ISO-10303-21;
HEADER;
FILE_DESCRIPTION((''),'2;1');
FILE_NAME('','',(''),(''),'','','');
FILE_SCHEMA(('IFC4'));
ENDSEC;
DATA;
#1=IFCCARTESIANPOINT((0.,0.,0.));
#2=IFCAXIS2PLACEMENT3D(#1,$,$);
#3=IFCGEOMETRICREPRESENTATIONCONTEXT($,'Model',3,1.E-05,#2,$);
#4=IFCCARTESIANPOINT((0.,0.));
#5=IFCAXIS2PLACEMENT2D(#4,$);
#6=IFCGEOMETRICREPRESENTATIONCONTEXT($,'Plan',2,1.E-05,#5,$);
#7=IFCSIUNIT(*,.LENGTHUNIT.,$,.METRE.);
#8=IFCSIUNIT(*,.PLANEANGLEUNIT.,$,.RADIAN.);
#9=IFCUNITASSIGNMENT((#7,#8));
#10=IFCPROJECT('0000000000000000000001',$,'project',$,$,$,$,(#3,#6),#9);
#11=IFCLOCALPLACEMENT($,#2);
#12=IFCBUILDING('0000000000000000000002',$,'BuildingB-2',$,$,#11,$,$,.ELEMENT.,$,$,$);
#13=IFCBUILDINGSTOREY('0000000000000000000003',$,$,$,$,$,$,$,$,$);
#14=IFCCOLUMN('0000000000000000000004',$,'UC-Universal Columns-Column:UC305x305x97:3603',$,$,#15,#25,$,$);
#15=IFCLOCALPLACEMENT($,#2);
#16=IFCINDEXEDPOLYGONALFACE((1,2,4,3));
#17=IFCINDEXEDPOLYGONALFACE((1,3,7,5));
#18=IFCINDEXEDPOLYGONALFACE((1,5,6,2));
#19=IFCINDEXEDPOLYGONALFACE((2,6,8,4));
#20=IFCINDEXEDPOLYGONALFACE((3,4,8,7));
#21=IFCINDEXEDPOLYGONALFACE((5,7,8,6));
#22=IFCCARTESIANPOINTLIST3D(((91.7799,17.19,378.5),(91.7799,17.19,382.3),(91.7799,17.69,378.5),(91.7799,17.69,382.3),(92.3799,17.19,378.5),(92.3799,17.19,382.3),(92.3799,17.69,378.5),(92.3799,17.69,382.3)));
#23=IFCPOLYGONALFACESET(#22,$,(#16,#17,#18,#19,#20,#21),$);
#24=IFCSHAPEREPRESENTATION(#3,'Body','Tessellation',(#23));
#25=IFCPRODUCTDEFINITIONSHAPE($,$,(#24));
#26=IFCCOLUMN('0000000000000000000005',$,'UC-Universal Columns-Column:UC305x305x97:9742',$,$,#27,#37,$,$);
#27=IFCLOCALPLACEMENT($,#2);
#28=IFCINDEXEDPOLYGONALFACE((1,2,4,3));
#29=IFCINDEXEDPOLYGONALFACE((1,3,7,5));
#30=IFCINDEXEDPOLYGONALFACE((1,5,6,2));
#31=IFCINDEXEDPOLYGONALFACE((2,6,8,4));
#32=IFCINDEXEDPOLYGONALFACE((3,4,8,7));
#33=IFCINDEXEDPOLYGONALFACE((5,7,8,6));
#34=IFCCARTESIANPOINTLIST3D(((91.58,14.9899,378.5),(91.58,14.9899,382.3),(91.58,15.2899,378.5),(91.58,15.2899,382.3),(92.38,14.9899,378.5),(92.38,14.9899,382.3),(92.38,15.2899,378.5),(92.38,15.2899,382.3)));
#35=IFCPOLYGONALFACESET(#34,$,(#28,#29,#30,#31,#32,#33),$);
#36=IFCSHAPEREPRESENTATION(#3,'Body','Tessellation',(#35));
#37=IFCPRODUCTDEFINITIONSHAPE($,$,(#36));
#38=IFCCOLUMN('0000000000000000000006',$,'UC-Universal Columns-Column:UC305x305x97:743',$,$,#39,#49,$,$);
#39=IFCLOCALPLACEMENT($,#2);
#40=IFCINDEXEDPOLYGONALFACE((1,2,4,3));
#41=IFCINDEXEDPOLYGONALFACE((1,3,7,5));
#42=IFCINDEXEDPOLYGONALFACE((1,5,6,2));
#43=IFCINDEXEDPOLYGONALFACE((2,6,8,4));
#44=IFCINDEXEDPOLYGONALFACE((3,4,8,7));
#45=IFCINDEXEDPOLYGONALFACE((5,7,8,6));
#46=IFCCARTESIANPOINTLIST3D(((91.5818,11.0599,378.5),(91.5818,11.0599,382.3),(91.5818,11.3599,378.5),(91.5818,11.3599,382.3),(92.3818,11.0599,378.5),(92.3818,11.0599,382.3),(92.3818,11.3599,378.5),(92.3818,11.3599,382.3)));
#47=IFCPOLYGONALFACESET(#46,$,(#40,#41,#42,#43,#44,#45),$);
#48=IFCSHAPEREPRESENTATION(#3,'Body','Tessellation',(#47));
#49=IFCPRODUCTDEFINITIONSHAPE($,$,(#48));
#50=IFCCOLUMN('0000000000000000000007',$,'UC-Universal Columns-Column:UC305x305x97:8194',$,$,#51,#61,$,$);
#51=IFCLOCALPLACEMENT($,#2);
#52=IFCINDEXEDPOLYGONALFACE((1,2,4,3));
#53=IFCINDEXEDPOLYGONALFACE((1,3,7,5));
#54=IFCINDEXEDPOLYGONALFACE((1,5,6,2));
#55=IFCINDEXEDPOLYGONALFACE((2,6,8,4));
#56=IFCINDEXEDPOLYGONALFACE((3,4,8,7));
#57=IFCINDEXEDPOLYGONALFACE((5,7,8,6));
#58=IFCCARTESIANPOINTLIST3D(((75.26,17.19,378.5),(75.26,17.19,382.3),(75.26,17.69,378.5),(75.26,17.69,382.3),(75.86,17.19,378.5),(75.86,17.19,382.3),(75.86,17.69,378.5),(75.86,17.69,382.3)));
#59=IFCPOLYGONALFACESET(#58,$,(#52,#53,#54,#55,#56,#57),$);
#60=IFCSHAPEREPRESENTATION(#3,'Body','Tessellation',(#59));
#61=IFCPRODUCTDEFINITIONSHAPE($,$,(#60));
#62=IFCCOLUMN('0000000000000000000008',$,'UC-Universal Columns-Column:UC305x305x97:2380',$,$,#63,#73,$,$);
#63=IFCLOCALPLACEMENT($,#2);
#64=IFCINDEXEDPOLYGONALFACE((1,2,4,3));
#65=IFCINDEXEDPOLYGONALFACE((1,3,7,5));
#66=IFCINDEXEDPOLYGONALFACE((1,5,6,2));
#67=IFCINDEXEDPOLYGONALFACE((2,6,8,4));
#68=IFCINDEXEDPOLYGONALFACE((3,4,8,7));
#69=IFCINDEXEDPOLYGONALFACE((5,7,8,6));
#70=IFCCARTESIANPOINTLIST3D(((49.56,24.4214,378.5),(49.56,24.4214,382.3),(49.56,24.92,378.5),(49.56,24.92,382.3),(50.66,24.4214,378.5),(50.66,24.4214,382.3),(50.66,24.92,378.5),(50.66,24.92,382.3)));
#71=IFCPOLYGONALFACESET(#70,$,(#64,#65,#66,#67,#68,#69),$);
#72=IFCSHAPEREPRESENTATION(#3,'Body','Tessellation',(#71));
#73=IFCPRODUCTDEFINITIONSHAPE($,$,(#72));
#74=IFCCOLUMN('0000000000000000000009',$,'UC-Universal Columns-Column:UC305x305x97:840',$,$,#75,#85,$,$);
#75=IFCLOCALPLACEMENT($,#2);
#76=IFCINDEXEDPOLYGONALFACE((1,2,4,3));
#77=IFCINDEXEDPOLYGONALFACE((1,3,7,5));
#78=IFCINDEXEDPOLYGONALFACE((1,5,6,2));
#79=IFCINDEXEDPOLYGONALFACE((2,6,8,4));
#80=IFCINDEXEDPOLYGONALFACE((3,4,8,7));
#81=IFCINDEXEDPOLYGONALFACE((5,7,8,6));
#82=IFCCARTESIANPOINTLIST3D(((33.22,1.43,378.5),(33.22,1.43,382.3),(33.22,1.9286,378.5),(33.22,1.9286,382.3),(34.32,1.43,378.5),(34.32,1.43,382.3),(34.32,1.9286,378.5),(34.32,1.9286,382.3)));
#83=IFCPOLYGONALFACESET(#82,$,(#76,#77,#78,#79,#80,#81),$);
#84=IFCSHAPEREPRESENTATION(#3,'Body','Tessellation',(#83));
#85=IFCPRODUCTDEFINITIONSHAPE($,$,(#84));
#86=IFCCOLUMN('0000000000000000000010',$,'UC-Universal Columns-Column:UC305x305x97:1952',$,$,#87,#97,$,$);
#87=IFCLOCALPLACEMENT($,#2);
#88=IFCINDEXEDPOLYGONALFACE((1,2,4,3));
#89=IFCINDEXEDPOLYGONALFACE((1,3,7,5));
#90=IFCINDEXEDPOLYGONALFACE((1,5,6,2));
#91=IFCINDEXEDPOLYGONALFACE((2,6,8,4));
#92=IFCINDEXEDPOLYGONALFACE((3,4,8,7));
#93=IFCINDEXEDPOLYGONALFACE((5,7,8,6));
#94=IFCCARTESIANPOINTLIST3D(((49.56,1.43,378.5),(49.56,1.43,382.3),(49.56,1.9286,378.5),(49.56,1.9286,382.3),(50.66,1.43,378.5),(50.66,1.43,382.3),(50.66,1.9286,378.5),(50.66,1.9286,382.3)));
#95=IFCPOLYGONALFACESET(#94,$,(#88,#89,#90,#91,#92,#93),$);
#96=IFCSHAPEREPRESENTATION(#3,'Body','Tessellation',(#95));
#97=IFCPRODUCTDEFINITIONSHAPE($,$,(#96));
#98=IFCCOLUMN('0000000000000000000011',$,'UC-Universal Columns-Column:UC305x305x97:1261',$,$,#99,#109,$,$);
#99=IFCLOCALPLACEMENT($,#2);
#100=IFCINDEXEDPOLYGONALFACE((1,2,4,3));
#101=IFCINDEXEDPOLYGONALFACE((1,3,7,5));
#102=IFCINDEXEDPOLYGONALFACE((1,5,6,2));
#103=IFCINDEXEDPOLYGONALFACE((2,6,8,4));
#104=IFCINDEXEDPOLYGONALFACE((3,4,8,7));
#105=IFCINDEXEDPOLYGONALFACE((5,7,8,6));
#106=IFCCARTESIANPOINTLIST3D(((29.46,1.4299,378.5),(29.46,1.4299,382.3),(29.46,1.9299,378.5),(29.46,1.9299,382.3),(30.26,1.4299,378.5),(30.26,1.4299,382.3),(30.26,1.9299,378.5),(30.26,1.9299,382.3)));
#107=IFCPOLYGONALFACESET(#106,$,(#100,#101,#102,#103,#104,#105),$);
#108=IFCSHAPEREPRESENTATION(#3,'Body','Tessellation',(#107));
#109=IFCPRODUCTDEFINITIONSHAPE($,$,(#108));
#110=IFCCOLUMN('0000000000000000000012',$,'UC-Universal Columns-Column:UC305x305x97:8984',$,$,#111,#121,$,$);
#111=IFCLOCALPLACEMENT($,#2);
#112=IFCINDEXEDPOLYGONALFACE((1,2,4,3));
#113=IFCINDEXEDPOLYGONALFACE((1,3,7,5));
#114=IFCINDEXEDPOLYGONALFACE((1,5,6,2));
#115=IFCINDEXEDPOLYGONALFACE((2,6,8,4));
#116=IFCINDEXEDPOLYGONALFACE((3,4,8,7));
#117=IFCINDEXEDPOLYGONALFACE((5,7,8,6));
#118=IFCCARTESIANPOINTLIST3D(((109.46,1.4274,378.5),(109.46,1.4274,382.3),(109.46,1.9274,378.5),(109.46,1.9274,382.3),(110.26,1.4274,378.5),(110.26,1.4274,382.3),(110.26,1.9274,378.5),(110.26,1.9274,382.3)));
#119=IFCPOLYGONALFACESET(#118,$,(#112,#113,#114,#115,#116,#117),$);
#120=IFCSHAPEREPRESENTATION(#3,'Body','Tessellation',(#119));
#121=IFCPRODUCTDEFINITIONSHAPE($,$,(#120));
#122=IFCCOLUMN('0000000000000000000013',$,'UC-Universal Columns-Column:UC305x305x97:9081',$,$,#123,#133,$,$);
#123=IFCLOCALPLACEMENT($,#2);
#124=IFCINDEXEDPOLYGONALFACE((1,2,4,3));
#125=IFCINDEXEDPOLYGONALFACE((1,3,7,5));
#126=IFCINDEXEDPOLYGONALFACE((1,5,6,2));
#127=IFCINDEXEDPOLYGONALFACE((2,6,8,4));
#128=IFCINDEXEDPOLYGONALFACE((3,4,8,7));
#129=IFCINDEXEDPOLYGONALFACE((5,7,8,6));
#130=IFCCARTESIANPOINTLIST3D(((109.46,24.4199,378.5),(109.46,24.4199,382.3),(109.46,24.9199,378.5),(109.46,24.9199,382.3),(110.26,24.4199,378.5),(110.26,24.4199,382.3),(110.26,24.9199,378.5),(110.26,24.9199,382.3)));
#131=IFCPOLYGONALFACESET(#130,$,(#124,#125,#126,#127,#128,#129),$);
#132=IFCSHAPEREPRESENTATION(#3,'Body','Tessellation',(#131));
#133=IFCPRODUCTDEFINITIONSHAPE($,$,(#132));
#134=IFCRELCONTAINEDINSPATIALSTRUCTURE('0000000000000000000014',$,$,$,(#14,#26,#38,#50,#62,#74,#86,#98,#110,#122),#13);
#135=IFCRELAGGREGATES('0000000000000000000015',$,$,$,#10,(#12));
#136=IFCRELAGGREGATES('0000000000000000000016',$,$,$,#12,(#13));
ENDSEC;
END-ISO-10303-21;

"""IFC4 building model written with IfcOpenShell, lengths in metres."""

from ifc_helpers import new_model, si_unit, origin, origin_2d, place, context, project, spatial, polyline, outline, extrude, element, save


model = new_model("IFC4")

# Units and contexts
model_context = context("Model", 3, precision=1e-05, world=origin())
plan_context = context("Plan", 2, precision=1e-05, world=origin_2d())
ifc_project = project(units=[si_unit("LENGTHUNIT", "METRE"), si_unit("PLANEANGLEUNIT", "RADIAN")], contexts=[model_context, plan_context])

# Building, storey
building_placement = place(None, origin())
building = spatial("IfcBuilding", under=ifc_project, at=building_placement, Name="BuildingB-2", CompositionType="ELEMENT")
storey = spatial("IfcBuildingStorey", under=building)

# Columns
element("IfcColumn", 1, inside=storey, Name="UC-Universal Columns-Column:UC305x305x97:3603", context=model_context, shape_type="SweptSolid", body=[
    extrude(outline(polyline([(92.3799, 17.69, 382.3), (91.7799, 17.69, 382.3), (91.7799, 17.19, 382.3), (92.3799, 17.19, 382.3), (92.3799, 17.69, 382.3)])), None, (0.0, 0.0, -1.0), 3.8),
])
element("IfcColumn", 2, inside=storey, Name="UC-Universal Columns-Column:UC305x305x97:9742", context=model_context, shape_type="SweptSolid", body=[
    extrude(outline(polyline([(92.38, 15.2899, 382.3), (91.58, 15.2899, 382.3), (91.58, 14.9899, 382.3), (92.38, 14.9899, 382.3), (92.38, 15.2899, 382.3)])), None, (0.0, 0.0, -1.0), 3.8),
])
element("IfcColumn", 3, inside=storey, Name="UC-Universal Columns-Column:UC305x305x97:743", context=model_context, shape_type="SweptSolid", body=[
    extrude(outline(polyline([(92.3818, 11.0599, 382.3), (91.5818, 11.0599, 382.3), (91.5818, 11.3599, 382.3), (92.3818, 11.3599, 382.3), (92.3818, 11.0599, 382.3)])), None, (0.0, 0.0, -1.0), 3.8),
])
element("IfcColumn", 4, inside=storey, Name="UC-Universal Columns-Column:UC305x305x97:8194", context=model_context, shape_type="SweptSolid", body=[
    extrude(outline(polyline([(75.26, 17.69, 382.3), (75.86, 17.69, 382.3), (75.86, 17.19, 382.3), (75.26, 17.19, 382.3), (75.26, 17.69, 382.3)])), None, (0.0, 0.0, -1.0), 3.8),
])
element("IfcColumn", 5, inside=storey, Name="UC-Universal Columns-Column:UC305x305x97:2380", context=model_context, shape_type="SweptSolid", body=[
    extrude(outline(polyline([(50.66, 24.4214, 382.3), (49.56, 24.4214, 382.3), (49.56, 24.92, 382.3), (50.66, 24.92, 382.3), (50.66, 24.4214, 382.3)])), None, (0.0, 0.0, -1.0), 3.8),
])
element("IfcColumn", 6, inside=storey, Name="UC-Universal Columns-Column:UC305x305x97:840", context=model_context, shape_type="SweptSolid", body=[
    extrude(outline(polyline([(34.32, 1.43, 382.3), (33.22, 1.43, 382.3), (33.22, 1.9286, 382.3), (34.32, 1.9286, 382.3), (34.32, 1.43, 382.3)])), None, (0.0, 0.0, -1.0), 3.8),
])
element("IfcColumn", 7, inside=storey, Name="UC-Universal Columns-Column:UC305x305x97:1952", context=model_context, shape_type="SweptSolid", body=[
    extrude(outline(polyline([(50.66, 1.43, 382.3), (49.56, 1.43, 382.3), (49.56, 1.9286, 382.3), (50.66, 1.9286, 382.3), (50.66, 1.43, 382.3)])), None, (0.0, 0.0, -1.0), 3.8),
])
element("IfcColumn", 8, inside=storey, Name="UC-Universal Columns-Column:UC305x305x97:1261", context=model_context, shape_type="SweptSolid", body=[
    extrude(outline(polyline([(30.26, 1.4299, 382.3), (29.46, 1.4299, 382.3), (29.46, 1.9299, 382.3), (30.26, 1.9299, 382.3), (30.26, 1.4299, 382.3)])), None, (0.0, 0.0, -1.0), 3.8),
])
element("IfcColumn", 9, inside=storey, Name="UC-Universal Columns-Column:UC305x305x97:8984", context=model_context, shape_type="SweptSolid", body=[
    extrude(outline(polyline([(110.26, 1.4274, 382.3), (109.46, 1.4274, 382.3), (109.46, 1.9274, 382.3), (110.26, 1.9274, 382.3), (110.26, 1.4274, 382.3)])), None, (0.0, 0.0, -1.0), 3.8),
])
element("IfcColumn", 10, inside=storey, Name="UC-Universal Columns-Column:UC305x305x97:9081", context=model_context, shape_type="SweptSolid", body=[
    extrude(outline(polyline([(110.26, 24.4199, 382.3), (109.46, 24.4199, 382.3), (109.46, 24.9199, 382.3), (110.26, 24.9199, 382.3), (110.26, 24.4199, 382.3)])), None, (0.0, 0.0, -1.0), 3.8),
])

save(model, "model.ifc")
